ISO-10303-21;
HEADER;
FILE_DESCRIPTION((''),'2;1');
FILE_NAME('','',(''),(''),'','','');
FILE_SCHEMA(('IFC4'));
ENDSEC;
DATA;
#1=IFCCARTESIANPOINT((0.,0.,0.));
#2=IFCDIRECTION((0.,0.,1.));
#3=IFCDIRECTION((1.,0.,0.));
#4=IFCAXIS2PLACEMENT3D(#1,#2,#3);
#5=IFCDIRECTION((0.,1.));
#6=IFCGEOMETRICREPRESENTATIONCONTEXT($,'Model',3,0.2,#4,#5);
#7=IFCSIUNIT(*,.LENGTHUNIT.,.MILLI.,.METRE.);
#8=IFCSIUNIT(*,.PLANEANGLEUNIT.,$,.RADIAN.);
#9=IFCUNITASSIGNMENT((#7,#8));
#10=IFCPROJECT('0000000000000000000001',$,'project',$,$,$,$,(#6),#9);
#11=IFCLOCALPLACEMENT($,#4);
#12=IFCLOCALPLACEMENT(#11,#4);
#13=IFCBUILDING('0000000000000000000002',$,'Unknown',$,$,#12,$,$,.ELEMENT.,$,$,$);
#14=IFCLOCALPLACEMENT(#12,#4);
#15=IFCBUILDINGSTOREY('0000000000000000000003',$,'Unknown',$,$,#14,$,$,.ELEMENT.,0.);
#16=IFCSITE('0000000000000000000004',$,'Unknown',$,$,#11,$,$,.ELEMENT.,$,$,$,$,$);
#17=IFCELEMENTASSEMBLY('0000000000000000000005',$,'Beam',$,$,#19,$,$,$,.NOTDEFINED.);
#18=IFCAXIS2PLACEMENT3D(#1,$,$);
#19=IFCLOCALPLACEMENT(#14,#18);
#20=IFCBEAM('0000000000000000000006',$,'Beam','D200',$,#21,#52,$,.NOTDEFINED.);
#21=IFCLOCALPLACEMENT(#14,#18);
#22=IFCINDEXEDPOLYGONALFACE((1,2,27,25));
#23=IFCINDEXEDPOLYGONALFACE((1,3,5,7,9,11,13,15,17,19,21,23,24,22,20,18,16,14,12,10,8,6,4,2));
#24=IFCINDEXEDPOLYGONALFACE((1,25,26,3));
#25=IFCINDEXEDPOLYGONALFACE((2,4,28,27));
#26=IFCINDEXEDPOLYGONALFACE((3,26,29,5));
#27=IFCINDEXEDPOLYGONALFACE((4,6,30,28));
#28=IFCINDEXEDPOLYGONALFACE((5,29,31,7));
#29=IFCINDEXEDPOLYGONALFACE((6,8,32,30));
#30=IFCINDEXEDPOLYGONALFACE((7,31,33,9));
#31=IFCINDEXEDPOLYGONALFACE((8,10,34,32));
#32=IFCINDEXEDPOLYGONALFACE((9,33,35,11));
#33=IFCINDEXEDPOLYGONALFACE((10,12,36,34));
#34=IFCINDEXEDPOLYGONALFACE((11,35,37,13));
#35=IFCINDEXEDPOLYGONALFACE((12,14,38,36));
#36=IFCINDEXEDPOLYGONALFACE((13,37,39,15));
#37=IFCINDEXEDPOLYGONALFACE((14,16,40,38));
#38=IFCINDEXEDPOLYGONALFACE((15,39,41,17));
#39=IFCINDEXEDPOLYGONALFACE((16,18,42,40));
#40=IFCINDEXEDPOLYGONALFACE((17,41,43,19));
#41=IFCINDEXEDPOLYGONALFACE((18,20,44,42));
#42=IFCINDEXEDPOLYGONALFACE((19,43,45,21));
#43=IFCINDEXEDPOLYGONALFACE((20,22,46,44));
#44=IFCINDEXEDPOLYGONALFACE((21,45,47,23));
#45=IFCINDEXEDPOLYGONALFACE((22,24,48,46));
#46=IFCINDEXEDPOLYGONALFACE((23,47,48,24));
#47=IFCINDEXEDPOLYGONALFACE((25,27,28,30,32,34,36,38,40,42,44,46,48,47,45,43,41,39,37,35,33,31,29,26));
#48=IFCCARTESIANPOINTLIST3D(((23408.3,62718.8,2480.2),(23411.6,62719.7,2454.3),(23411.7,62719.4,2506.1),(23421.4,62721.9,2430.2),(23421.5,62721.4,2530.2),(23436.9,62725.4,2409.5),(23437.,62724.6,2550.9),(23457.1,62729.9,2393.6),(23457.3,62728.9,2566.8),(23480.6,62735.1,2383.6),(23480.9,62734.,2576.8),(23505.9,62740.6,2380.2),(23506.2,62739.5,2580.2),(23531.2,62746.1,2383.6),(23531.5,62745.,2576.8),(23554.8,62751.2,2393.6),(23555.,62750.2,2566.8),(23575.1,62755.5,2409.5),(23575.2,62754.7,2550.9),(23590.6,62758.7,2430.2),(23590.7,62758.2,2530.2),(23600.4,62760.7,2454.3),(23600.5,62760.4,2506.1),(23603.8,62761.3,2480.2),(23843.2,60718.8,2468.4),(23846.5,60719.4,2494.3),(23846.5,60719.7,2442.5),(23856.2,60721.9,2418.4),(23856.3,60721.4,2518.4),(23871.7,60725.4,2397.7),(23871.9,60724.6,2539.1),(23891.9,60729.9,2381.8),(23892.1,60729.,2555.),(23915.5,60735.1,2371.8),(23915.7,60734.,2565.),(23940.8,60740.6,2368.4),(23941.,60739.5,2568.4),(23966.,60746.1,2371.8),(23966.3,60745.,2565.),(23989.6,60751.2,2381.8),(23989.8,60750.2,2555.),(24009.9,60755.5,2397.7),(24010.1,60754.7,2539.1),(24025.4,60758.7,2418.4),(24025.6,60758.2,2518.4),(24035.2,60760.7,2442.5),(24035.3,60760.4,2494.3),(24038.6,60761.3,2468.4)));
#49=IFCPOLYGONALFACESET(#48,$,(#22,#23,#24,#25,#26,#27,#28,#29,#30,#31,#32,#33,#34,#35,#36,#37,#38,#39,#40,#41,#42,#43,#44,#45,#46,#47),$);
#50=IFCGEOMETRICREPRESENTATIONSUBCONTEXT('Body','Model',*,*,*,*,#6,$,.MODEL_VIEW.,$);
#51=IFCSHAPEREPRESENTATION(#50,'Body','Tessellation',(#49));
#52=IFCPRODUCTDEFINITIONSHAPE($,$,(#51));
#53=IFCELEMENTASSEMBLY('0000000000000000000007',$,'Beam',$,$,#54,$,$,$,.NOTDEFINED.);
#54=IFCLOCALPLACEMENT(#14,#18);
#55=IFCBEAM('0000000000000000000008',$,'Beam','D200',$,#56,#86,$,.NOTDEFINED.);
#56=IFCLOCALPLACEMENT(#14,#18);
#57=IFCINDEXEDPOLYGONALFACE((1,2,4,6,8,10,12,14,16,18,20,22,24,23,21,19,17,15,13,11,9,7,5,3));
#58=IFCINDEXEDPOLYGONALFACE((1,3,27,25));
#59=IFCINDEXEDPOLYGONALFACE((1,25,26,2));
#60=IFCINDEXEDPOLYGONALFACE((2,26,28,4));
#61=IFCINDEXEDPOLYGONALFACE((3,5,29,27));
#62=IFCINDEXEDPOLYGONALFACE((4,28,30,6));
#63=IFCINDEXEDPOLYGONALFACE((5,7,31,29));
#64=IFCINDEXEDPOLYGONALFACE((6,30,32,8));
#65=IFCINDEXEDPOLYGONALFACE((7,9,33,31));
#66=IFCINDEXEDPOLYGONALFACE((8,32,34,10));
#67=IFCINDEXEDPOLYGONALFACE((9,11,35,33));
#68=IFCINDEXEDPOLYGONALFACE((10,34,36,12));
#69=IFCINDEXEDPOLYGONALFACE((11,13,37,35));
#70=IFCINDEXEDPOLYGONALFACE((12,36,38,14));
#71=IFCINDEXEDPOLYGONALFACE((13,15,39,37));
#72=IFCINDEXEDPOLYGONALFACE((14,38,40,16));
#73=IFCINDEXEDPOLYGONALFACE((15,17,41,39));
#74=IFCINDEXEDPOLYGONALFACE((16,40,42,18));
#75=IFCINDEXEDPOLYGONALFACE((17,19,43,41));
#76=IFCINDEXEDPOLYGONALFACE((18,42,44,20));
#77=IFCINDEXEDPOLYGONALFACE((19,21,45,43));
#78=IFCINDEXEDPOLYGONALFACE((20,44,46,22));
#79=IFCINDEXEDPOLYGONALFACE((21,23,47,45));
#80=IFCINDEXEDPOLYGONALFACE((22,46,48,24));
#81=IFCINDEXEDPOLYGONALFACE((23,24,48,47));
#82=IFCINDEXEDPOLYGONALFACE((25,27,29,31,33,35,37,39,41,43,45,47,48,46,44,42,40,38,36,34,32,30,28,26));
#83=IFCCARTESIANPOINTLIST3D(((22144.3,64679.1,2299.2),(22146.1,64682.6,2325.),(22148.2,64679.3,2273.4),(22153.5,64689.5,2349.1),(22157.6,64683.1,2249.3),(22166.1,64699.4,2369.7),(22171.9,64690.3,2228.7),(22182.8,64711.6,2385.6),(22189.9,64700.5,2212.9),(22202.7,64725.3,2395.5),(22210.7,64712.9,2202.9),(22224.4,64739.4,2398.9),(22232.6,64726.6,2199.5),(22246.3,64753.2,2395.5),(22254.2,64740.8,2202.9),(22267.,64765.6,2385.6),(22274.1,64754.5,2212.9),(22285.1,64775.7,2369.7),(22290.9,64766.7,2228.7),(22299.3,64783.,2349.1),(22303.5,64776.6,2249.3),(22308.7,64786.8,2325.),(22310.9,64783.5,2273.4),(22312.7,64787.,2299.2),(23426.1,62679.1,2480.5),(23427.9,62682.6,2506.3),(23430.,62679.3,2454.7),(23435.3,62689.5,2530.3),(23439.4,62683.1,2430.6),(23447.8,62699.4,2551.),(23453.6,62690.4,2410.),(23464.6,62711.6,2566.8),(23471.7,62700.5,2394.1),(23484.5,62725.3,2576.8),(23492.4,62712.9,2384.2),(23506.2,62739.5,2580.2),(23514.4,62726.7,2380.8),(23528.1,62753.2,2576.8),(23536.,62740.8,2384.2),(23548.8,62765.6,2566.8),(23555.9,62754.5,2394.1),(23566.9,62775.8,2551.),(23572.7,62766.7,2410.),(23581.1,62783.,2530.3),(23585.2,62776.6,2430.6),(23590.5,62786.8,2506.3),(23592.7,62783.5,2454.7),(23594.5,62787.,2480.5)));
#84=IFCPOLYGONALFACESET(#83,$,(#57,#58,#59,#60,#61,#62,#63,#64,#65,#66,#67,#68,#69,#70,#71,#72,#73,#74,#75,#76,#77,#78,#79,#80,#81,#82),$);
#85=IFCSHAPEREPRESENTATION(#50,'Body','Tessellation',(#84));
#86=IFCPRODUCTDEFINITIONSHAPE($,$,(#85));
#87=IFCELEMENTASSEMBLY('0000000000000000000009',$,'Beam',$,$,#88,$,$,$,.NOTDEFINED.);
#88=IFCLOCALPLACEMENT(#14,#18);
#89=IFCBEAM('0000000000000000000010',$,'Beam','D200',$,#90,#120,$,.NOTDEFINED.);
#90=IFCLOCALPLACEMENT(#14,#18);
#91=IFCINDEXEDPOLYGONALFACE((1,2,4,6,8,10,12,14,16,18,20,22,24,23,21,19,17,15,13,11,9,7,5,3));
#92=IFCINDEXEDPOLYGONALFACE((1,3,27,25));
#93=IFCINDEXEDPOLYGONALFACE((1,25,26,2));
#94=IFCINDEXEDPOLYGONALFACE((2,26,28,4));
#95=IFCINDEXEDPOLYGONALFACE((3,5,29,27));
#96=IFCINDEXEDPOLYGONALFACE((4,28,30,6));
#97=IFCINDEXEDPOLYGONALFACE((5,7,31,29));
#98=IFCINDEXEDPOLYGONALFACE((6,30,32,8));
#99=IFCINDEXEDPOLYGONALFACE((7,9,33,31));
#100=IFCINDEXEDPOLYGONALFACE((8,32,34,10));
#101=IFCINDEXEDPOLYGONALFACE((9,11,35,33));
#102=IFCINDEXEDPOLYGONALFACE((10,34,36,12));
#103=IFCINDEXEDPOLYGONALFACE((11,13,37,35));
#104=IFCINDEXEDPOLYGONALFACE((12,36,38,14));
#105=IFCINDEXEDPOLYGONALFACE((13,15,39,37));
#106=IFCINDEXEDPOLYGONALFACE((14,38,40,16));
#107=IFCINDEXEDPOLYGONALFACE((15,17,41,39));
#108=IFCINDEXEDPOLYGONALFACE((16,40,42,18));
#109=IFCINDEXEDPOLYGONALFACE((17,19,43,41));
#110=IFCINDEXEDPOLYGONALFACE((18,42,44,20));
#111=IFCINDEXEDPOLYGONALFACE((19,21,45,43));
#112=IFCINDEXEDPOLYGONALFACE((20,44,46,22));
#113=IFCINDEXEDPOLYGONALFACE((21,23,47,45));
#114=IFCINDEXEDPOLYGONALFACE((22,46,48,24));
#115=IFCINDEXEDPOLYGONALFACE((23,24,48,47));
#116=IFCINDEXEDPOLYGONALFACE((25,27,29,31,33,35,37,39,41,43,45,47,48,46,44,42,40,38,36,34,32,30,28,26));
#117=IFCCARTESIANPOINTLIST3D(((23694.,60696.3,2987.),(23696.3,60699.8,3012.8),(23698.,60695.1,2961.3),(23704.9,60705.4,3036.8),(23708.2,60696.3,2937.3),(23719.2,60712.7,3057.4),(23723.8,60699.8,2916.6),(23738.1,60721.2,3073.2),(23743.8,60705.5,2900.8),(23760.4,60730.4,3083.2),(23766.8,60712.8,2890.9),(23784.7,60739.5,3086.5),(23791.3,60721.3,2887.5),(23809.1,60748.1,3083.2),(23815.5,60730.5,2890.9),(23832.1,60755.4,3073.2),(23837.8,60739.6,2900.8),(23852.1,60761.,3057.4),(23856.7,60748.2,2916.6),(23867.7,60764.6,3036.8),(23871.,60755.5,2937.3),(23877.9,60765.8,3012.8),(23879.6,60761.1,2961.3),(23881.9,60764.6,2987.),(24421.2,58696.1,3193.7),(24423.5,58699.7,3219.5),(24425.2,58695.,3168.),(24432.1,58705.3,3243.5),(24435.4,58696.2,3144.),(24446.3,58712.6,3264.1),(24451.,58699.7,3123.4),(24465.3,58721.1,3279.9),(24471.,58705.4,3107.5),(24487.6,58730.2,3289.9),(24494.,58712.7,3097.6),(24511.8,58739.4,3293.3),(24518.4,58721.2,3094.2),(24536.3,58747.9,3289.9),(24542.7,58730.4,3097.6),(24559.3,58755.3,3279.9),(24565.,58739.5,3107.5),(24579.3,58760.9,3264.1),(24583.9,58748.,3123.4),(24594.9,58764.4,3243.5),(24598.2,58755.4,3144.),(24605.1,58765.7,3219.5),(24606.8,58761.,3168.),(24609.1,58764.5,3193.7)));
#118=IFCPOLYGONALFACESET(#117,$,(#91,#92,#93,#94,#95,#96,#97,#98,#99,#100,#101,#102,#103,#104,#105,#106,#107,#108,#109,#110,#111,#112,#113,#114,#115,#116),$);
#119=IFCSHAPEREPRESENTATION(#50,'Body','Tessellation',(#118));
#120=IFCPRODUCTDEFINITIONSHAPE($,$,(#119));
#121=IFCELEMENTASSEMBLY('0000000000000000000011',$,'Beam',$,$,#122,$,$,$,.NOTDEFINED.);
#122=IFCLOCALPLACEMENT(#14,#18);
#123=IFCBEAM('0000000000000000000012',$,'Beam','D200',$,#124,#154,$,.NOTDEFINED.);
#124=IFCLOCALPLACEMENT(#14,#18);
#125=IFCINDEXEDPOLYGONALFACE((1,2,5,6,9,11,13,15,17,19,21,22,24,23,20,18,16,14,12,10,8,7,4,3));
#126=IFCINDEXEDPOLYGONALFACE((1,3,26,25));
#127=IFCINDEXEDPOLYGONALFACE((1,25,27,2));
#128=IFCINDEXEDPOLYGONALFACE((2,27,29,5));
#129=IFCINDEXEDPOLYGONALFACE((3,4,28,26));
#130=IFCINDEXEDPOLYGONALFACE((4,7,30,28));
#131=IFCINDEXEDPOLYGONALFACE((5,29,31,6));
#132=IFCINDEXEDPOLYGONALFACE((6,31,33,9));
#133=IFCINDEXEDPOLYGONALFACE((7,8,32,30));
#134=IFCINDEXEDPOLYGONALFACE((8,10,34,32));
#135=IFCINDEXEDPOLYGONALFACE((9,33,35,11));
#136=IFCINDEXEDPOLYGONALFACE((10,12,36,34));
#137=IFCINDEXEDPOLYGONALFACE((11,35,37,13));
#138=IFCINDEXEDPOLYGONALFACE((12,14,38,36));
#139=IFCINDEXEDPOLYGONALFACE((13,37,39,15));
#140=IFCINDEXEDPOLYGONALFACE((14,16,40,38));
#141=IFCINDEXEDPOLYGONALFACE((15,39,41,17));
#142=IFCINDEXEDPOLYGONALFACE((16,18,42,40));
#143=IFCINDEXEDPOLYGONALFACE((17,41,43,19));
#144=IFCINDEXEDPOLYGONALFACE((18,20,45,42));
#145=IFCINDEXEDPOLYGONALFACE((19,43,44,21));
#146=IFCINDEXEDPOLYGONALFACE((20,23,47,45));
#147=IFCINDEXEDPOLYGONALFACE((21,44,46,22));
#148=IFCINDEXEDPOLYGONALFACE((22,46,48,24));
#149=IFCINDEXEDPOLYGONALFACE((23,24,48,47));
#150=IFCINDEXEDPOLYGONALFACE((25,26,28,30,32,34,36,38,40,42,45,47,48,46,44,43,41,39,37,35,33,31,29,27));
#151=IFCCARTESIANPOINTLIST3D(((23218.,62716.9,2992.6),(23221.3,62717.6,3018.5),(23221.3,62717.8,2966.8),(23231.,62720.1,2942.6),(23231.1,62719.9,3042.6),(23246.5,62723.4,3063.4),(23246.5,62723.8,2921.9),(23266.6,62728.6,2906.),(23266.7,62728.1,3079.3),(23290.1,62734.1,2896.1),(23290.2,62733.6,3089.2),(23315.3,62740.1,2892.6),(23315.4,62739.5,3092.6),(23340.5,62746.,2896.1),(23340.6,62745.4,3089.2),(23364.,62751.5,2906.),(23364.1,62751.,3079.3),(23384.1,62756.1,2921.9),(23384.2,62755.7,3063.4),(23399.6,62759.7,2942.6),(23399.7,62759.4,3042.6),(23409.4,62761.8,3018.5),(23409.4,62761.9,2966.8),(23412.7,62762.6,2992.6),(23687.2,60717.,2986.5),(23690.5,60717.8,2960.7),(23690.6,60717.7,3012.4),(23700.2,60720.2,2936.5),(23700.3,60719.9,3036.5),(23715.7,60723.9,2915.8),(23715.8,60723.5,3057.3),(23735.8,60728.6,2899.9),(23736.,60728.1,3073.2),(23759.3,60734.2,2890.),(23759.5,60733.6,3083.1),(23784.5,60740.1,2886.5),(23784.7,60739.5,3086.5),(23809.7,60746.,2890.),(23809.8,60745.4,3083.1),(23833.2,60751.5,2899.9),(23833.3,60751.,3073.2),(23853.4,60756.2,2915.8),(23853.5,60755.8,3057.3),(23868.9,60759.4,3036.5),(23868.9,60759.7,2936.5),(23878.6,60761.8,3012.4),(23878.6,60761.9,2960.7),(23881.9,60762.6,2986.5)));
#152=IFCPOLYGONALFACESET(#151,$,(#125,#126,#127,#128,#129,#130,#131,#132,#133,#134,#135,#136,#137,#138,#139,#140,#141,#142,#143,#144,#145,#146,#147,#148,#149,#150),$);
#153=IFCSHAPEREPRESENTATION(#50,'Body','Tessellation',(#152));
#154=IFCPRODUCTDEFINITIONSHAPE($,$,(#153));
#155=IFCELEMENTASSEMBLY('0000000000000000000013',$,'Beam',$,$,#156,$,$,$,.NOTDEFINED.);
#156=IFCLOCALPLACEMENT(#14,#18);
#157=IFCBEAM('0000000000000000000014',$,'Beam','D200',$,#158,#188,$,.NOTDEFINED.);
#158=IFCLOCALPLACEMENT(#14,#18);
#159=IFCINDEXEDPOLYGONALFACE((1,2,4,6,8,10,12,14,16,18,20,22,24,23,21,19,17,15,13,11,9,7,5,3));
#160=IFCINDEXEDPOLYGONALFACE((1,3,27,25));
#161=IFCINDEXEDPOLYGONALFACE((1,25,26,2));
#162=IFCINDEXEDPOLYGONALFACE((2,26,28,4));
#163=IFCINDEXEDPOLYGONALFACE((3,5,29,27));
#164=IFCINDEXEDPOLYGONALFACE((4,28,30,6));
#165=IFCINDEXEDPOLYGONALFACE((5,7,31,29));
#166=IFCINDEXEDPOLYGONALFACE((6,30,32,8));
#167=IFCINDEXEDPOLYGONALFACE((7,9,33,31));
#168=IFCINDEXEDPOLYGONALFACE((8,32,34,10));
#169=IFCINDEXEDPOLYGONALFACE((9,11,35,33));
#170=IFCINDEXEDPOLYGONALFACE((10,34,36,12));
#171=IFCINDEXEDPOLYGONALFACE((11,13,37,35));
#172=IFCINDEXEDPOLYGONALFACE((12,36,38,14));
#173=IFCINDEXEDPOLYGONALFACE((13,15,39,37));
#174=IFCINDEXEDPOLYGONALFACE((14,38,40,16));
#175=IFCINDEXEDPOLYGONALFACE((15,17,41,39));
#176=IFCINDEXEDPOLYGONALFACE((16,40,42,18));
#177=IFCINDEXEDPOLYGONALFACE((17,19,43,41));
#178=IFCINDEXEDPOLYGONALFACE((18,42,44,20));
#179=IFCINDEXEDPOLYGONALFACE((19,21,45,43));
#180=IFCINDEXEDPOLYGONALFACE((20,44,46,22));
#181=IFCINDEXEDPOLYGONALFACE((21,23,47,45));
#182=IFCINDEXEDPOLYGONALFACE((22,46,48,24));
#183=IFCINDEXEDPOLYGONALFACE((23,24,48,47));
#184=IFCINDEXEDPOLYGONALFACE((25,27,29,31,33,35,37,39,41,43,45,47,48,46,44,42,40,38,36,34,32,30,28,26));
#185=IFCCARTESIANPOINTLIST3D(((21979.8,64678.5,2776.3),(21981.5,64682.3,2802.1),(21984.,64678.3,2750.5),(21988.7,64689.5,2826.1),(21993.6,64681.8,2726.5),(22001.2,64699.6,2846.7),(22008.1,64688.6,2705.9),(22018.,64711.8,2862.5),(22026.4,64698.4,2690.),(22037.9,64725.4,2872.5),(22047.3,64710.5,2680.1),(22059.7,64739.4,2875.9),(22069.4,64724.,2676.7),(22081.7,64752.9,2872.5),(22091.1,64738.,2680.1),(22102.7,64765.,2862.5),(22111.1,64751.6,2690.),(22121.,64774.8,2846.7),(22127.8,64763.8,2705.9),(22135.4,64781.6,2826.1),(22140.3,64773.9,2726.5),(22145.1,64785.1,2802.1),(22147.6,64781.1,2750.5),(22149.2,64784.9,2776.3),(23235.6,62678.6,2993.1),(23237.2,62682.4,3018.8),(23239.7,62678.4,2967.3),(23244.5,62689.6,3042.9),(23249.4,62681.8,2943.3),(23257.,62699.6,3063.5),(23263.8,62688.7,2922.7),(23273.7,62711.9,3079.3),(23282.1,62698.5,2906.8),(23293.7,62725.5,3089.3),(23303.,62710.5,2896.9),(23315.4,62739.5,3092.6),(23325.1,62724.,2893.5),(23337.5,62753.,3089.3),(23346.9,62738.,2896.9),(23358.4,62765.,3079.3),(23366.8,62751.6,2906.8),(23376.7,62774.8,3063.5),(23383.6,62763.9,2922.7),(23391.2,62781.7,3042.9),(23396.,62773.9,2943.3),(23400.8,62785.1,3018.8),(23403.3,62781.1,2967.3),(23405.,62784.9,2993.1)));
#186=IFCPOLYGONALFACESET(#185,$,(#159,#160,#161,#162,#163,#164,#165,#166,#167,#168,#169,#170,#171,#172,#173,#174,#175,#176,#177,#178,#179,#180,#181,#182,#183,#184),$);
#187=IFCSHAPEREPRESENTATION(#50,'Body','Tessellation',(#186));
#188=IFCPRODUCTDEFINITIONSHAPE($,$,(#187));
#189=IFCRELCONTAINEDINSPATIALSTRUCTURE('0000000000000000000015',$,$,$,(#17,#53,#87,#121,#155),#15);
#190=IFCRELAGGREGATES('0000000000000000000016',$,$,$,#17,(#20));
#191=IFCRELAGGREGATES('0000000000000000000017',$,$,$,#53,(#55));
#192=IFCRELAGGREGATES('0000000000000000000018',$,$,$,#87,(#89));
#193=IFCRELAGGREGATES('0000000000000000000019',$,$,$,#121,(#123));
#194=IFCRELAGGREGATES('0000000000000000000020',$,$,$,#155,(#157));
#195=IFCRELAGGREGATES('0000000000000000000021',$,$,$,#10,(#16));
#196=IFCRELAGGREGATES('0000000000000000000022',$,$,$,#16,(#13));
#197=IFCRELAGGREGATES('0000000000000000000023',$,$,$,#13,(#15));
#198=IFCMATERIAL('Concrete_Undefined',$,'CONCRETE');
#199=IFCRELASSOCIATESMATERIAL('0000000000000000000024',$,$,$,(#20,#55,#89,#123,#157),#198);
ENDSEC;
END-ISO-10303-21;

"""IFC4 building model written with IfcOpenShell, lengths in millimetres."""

from ifc_helpers import new_model, si_unit, direction, frame, origin_with_axes, place, context, subcontext, project, spatial, line, indexed_curve, outline, extrude, material, element, aggregate, save


model = new_model("IFC4")

# Units and contexts
model_context = context("Model", 3, precision=0.2, world=origin_with_axes(), true_north=direction((0.0, 1.0)))
body_context = subcontext(model_context, "Body", "Model", "MODEL_VIEW")
ifc_project = project(units=[si_unit("LENGTHUNIT", "METRE", prefix="MILLI"), si_unit("PLANEANGLEUNIT", "RADIAN")], contexts=[model_context])

# Site, building, storey
site_placement = place(None, origin_with_axes())
site = spatial("IfcSite", under=ifc_project, at=site_placement, Name="Unknown", CompositionType="ELEMENT")
building_placement = place(site_placement, origin_with_axes())
building = spatial("IfcBuilding", under=site, at=building_placement, Name="Unknown", CompositionType="ELEMENT")
storey_placement = place(building_placement, origin_with_axes())
storey = spatial("IfcBuildingStorey", under=building, at=storey_placement, Name="Unknown", CompositionType="ELEMENT", Elevation=0.0)

# Element assemblies, beams
ifc_material = material(Name="Concrete_Undefined", Category="CONCRETE")
assembly_1_placement = place(storey_placement, frame((23506.0, 62740.0, 2480.2), z_axis=(-0.977171, -0.212456, 0.0), x_axis=(0.212452, -0.977154, -0.005779)))
assembly_1 = element("IfcElementAssembly", 1, at=assembly_1_placement, inside=storey, Name="Beam", PredefinedType="NOTDEFINED")
beam_1_placement = place(assembly_1_placement, origin_with_axes())
beam_1 = element("IfcBeam", 2, at=beam_1_placement, material=ifc_material, Name="Beam", Description="D200", PredefinedType="NOTDEFINED", context=body_context, shape_type="SolidModel", body=[
    extrude(outline(indexed_curve([(100.0, 0.0), (96.6, 25.9), (86.6, 50.0), (70.7, 70.7), (50.0, 86.6), (25.9, 96.6), (0.0, 100.0), (-25.9, 96.6), (-50.0, 86.6), (-70.7, 70.7), (-86.6, 50.0), (-96.6, 25.9), (-100.0, 0.0), (-96.6, -25.9), (-86.6, -50.0), (-70.7, -70.7), (-50.0, -86.6), (-25.9, -96.6), (0.0, -100.0), (25.9, -96.6), (50.0, -86.6), (70.7, -70.7), (86.6, -50.0), (96.6, -25.9)], segments=[line(1, 2, 3, 4, 5, 6, 7, 8, 9, 10, 11, 12, 13, 14, 15, 16, 17, 18, 19, 20, 21, 22, 23, 24, 1)])), frame((0.0, 0.0, 0.0), z_axis=(-1.0, 0.0, 0.0), x_axis=(0.0, 0.0, 1.0)), (0.0, 0.0, -1.0), 2046.7),
])
aggregate(assembly_1, [beam_1])
assembly_2_placement = place(storey_placement, frame((22228.5, 64733.0, 2299.2), z_axis=(-0.841926, -0.539592, 0.0), x_axis=(0.538028, -0.839485, 0.076095)))
assembly_2 = element("IfcElementAssembly", 3, at=assembly_2_placement, inside=storey, Name="Beam", PredefinedType="NOTDEFINED")
beam_2_placement = place(assembly_2_placement, origin_with_axes())
beam_2 = element("IfcBeam", 4, at=beam_2_placement, material=ifc_material, Name="Beam", Description="D200", PredefinedType="NOTDEFINED", context=body_context, shape_type="SolidModel", body=[
    extrude(outline(indexed_curve([(100.0, 0.0), (96.6, 25.9), (86.6, 50.0), (70.7, 70.7), (50.0, 86.6), (25.9, 96.6), (0.0, 100.0), (-25.9, 96.6), (-50.0, 86.6), (-70.7, 70.7), (-86.6, 50.0), (-96.6, 25.9), (-100.0, 0.0), (-96.6, -25.9), (-86.6, -50.0), (-70.7, -70.7), (-50.0, -86.6), (-25.9, -96.6), (0.0, -100.0), (25.9, -96.6), (50.0, -86.6), (70.7, -70.7), (86.6, -50.0), (96.6, -25.9)], segments=[line(1, 2, 3, 4, 5, 6, 7, 8, 9, 10, 11, 12, 13, 14, 15, 16, 17, 18, 19, 20, 21, 22, 23, 24, 1)])), frame((0.0, 0.0, 0.0), z_axis=(-1.0, 0.0, 0.0), x_axis=(0.0, 0.0, 1.0)), (0.0, 0.0, -1.0), 2382.4),
])
aggregate(assembly_2, [beam_2])
assembly_3_placement = place(storey_placement, frame((23788.0, 60730.4, 2987.0), z_axis=(-0.939814, -0.341688, 0.0), x_axis=(0.340087, -0.935411, 0.096679)))
assembly_3 = element("IfcElementAssembly", 5, at=assembly_3_placement, inside=storey, Name="Beam", PredefinedType="NOTDEFINED")
beam_3_placement = place(assembly_3_placement, origin_with_axes())
beam_3 = element("IfcBeam", 6, at=beam_3_placement, material=ifc_material, Name="Beam", Description="D200", PredefinedType="NOTDEFINED", context=body_context, shape_type="SolidModel", body=[
    extrude(outline(indexed_curve([(100.0, 0.0), (96.6, 25.9), (86.6, 50.0), (70.7, 70.7), (50.0, 86.6), (25.9, 96.6), (0.0, 100.0), (-25.9, 96.6), (-50.0, 86.6), (-70.7, 70.7), (-86.6, 50.0), (-96.6, 25.9), (-100.0, 0.0), (-96.6, -25.9), (-86.6, -50.0), (-70.7, -70.7), (-50.0, -86.6), (-25.9, -96.6), (0.0, -100.0), (25.9, -96.6), (50.0, -86.6), (70.7, -70.7), (86.6, -50.0), (96.6, -25.9)], segments=[line(1, 2, 3, 4, 5, 6, 7, 8, 9, 10, 11, 12, 13, 14, 15, 16, 17, 18, 19, 20, 21, 22, 23, 24, 1)])), frame((0.0, 0.0, 0.0), z_axis=(-1.0, 0.0, 0.0), x_axis=(0.0, 0.0, 1.0)), (0.0, 0.0, -1.0), 2138.2),
])
aggregate(assembly_3, [beam_3])
assembly_4_placement = place(storey_placement, frame((23315.3, 62739.8, 2992.6), z_axis=(-0.973563, -0.228421, 0.0), x_axis=(0.22842, -0.973558, -0.002969)))
assembly_4 = element("IfcElementAssembly", 7, at=assembly_4_placement, inside=storey, Name="Beam", PredefinedType="NOTDEFINED")
beam_4_placement = place(assembly_4_placement, origin_with_axes())
beam_4 = element("IfcBeam", 8, at=beam_4_placement, material=ifc_material, Name="Beam", Description="D200", PredefinedType="NOTDEFINED", context=body_context, shape_type="SolidModel", body=[
    extrude(outline(indexed_curve([(100.0, 0.0), (96.6, 25.9), (86.6, 50.0), (70.7, 70.7), (50.0, 86.6), (25.9, 96.6), (0.0, 100.0), (-25.9, 96.6), (-50.0, 86.6), (-70.7, 70.7), (-86.6, 50.0), (-96.6, 25.9), (-100.0, 0.0), (-96.6, -25.9), (-86.6, -50.0), (-70.7, -70.7), (-50.0, -86.6), (-25.9, -96.6), (0.0, -100.0), (25.9, -96.6), (50.0, -86.6), (70.7, -70.7), (86.6, -50.0), (96.6, -25.9)], segments=[line(1, 2, 3, 4, 5, 6, 7, 8, 9, 10, 11, 12, 13, 14, 15, 16, 17, 18, 19, 20, 21, 22, 23, 24, 1)])), frame((0.0, 0.0, 0.0), z_axis=(-1.0, 0.0, 0.0), x_axis=(0.0, 0.0, 1.0)), (0.0, 0.0, -1.0), 2054.3),
])
aggregate(assembly_4, [beam_4])
assembly_5_placement = place(storey_placement, frame((22064.5, 64731.7, 2776.3), z_axis=(-0.846896, -0.531759, 0.0), x_axis=(0.529532, -0.84335, 0.091413)))
assembly_5 = element("IfcElementAssembly", 9, at=assembly_5_placement, inside=storey, Name="Beam", PredefinedType="NOTDEFINED")
beam_5_placement = place(assembly_5_placement, origin_with_axes())
beam_5 = element("IfcBeam", 10, at=beam_5_placement, material=ifc_material, Name="Beam", Description="D200", PredefinedType="NOTDEFINED", context=body_context, shape_type="SolidModel", body=[
    extrude(outline(indexed_curve([(100.0, 0.0), (96.6, 25.9), (86.6, 50.0), (70.7, 70.7), (50.0, 86.6), (25.9, 96.6), (0.0, 100.0), (-25.9, 96.6), (-50.0, 86.6), (-70.7, 70.7), (-86.6, 50.0), (-96.6, 25.9), (-100.0, 0.0), (-96.6, -25.9), (-86.6, -50.0), (-70.7, -70.7), (-50.0, -86.6), (-25.9, -96.6), (0.0, -100.0), (25.9, -96.6), (50.0, -86.6), (70.7, -70.7), (86.6, -50.0), (96.6, -25.9)], segments=[line(1, 2, 3, 4, 5, 6, 7, 8, 9, 10, 11, 12, 13, 14, 15, 16, 17, 18, 19, 20, 21, 22, 23, 24, 1)])), frame((0.0, 0.0, 0.0), z_axis=(-1.0, 0.0, 0.0), x_axis=(0.0, 0.0, 1.0)), (0.0, 0.0, -1.0), 2371.4),
])
aggregate(assembly_5, [beam_5])

save(model, "model.ifc")
